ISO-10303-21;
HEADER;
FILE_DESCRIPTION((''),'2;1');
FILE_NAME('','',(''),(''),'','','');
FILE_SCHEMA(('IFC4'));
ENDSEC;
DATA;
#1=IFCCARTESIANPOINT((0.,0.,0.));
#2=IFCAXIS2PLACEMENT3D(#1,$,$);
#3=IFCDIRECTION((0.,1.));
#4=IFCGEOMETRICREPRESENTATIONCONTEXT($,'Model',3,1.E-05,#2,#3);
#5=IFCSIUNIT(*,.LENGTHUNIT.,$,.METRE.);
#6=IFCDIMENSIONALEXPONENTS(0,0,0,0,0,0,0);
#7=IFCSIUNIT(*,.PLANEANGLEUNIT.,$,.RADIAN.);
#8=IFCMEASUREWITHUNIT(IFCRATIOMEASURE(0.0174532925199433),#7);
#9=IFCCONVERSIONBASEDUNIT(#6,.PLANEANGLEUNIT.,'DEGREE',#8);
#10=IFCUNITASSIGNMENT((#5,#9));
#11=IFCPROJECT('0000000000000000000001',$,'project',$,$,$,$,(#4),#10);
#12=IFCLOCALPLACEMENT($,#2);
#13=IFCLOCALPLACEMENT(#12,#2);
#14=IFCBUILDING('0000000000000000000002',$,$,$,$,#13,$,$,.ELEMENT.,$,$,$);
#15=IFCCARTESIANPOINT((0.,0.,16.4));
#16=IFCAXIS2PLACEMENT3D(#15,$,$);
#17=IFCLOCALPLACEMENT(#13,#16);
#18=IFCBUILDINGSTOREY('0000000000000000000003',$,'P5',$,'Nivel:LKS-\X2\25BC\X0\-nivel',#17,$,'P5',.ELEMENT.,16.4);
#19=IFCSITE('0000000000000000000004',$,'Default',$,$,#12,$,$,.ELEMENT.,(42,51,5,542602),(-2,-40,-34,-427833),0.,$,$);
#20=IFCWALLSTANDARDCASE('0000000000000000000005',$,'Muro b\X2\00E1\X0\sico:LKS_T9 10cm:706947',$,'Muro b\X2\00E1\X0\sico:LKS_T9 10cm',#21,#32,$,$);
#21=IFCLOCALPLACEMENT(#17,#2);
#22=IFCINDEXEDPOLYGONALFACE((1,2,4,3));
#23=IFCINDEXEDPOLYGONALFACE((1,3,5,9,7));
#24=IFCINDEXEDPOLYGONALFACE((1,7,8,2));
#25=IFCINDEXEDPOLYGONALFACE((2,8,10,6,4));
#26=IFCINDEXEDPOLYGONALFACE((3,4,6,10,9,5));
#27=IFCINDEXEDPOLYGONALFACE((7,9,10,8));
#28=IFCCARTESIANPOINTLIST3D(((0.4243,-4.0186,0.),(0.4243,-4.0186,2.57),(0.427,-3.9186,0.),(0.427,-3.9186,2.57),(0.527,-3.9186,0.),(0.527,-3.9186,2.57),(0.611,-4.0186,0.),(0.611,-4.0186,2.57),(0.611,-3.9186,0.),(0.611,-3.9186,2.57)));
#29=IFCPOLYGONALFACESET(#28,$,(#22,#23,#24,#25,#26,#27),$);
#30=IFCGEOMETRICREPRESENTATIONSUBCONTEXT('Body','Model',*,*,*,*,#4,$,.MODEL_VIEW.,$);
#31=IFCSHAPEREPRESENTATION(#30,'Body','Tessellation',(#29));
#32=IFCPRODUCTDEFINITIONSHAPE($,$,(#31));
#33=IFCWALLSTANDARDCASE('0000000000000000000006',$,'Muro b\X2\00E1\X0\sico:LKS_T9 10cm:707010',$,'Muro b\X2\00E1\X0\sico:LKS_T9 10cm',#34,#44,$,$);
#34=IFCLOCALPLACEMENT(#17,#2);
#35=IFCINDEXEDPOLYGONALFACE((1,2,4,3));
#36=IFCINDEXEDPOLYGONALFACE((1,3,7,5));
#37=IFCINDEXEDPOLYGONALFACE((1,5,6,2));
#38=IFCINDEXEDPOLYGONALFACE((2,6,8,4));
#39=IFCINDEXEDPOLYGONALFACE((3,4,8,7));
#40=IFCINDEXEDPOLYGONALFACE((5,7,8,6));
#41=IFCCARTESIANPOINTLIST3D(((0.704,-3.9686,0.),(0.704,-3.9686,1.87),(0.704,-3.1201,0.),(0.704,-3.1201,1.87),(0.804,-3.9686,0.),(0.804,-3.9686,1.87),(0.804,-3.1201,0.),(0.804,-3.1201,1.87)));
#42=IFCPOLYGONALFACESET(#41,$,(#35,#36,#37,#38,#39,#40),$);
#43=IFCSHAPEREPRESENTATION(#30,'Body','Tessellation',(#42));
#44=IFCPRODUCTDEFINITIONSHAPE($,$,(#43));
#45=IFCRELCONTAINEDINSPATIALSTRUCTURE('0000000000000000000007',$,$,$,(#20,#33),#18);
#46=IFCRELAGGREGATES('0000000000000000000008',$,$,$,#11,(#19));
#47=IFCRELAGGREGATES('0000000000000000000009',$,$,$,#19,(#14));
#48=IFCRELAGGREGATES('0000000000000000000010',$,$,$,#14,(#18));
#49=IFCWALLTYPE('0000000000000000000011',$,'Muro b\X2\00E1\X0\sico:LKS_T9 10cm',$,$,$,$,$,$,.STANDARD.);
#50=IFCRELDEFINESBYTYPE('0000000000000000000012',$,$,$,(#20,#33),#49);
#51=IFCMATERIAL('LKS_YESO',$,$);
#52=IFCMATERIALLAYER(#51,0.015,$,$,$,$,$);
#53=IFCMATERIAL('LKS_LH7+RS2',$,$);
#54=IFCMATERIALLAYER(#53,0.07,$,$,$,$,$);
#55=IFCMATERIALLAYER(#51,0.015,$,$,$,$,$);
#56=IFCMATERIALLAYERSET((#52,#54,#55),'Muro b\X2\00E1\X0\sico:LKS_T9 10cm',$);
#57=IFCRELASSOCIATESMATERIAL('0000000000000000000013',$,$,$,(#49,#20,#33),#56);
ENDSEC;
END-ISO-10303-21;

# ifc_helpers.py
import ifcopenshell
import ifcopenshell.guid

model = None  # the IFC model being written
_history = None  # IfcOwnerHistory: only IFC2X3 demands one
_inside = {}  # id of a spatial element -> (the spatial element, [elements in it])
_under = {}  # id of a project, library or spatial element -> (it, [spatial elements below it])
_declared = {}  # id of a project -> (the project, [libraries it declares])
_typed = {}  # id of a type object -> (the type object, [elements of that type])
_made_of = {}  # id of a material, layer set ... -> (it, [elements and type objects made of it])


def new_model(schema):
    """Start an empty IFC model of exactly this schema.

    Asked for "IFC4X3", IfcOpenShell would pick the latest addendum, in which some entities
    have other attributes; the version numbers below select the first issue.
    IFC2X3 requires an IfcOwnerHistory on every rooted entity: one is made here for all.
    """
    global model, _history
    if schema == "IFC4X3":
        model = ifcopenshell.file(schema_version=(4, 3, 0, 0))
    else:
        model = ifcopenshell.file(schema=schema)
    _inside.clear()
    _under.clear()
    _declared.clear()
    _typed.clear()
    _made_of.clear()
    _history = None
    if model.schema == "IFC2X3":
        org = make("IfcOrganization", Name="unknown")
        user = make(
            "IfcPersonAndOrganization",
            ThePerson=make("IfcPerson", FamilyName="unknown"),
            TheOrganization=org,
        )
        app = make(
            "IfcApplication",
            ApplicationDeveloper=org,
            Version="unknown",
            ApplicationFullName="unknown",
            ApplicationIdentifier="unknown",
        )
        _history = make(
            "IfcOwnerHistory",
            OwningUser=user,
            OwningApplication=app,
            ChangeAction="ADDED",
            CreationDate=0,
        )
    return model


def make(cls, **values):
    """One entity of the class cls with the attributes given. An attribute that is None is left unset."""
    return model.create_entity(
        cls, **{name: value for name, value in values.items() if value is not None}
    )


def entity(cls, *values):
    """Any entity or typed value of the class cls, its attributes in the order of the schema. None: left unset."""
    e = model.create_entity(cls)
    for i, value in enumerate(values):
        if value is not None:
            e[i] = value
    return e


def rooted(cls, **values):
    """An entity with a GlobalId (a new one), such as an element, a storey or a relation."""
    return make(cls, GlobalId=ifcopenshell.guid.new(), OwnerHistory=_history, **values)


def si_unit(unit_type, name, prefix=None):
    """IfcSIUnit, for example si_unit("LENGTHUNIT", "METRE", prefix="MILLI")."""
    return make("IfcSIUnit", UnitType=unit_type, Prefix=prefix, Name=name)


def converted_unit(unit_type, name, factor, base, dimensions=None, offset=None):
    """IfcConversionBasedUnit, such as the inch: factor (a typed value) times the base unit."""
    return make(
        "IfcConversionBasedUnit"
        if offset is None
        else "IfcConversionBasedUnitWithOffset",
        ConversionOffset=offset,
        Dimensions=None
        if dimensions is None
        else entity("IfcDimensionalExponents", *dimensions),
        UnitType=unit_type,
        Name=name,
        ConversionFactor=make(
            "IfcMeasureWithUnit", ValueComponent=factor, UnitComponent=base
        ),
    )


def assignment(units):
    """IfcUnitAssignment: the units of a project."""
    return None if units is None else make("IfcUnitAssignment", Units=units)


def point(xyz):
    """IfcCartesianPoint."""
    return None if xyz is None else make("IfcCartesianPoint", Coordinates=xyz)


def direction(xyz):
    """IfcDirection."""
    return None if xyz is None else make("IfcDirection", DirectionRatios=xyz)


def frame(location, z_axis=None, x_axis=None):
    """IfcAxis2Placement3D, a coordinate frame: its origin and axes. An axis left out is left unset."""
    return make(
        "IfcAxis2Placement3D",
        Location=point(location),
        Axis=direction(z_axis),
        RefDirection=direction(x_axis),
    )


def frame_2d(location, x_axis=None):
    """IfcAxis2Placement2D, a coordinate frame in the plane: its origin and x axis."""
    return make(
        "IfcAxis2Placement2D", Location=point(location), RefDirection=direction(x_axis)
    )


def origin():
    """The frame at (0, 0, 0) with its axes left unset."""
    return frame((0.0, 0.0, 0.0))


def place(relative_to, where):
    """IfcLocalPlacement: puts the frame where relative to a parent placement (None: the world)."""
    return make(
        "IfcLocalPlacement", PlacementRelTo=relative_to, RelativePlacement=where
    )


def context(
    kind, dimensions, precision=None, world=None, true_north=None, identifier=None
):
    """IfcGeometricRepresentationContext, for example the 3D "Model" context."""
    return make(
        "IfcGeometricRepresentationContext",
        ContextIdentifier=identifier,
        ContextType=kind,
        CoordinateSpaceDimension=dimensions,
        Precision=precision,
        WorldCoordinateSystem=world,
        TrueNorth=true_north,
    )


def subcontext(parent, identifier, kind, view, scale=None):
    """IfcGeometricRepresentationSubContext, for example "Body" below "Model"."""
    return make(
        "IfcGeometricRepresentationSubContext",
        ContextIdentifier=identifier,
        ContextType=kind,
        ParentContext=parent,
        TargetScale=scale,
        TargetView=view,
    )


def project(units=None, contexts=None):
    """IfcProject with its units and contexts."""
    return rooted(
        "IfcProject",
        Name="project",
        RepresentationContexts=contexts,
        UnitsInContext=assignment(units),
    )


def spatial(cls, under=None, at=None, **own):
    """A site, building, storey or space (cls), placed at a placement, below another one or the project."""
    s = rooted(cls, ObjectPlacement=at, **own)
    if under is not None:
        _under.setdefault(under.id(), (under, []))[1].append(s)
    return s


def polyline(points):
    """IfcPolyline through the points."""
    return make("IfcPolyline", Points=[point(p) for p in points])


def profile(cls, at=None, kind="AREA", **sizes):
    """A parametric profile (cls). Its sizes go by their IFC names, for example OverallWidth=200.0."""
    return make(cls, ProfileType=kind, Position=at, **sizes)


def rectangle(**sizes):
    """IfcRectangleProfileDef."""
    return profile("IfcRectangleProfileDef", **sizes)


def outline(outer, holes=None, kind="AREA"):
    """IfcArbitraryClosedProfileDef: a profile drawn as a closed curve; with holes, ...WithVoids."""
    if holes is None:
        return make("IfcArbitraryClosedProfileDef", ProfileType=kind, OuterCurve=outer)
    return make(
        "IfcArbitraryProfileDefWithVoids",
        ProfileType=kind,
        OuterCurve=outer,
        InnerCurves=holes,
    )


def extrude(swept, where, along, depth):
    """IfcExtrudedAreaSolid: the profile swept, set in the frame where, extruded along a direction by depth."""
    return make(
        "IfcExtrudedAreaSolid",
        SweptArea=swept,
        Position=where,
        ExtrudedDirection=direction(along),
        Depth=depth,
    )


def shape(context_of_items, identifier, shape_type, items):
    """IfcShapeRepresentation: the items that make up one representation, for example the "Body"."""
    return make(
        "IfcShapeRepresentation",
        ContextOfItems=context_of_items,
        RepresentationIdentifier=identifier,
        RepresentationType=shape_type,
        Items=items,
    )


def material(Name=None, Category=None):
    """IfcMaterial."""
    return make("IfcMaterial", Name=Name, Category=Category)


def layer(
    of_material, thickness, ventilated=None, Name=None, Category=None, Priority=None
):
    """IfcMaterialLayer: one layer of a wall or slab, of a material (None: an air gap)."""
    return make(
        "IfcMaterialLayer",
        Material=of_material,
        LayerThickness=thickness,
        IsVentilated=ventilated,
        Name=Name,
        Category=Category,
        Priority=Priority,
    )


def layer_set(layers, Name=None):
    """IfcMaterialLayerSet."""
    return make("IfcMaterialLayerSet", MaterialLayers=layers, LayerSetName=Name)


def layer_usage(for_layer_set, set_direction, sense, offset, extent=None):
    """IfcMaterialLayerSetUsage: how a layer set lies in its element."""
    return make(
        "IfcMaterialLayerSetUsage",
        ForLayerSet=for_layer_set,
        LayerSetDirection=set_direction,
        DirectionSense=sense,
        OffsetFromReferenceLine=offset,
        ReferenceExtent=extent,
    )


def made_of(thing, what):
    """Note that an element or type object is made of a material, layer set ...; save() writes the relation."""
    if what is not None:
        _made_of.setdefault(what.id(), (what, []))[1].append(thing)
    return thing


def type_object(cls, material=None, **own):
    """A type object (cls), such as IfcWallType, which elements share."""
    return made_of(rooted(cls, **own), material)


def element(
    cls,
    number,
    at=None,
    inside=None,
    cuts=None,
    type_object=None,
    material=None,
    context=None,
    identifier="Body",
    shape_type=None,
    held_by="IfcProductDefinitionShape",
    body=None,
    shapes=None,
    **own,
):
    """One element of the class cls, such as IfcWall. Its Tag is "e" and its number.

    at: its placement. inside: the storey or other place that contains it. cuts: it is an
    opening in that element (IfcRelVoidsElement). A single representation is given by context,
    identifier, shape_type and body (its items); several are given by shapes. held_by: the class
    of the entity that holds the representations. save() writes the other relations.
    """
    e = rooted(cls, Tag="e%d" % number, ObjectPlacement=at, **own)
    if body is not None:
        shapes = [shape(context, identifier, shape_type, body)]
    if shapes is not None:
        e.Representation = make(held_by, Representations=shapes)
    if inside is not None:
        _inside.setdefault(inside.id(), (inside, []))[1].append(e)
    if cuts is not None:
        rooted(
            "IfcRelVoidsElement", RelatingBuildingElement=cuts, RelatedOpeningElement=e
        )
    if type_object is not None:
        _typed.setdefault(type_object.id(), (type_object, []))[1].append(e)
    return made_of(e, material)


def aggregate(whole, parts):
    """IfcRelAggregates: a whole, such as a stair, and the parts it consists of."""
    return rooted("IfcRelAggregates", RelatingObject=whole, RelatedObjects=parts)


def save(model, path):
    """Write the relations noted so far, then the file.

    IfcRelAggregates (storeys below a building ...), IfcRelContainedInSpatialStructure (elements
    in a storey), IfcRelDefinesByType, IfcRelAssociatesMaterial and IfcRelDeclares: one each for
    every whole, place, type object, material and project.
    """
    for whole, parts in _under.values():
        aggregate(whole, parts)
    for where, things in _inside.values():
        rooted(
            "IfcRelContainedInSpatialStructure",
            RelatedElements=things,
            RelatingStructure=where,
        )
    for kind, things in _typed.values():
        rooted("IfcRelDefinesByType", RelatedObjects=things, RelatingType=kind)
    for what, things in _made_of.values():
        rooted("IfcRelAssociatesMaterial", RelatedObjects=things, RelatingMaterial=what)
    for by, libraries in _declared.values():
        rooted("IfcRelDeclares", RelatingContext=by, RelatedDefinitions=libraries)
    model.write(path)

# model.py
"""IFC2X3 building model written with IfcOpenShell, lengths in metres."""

from ifc_helpers import new_model, entity, si_unit, converted_unit, direction, frame, frame_2d, origin, place, context, subcontext, project, spatial, polyline, rectangle, outline, extrude, material, layer, layer_set, layer_usage, type_object, element, save


model = new_model("IFC2X3")

# Units and contexts
model_context = context("Model", 3, precision=1e-05, world=origin(), true_north=direction((0.0, 1.0)))
body_context = subcontext(model_context, "Body", "Model", "MODEL_VIEW")
ifc_project = project(units=[si_unit("LENGTHUNIT", "METRE"), converted_unit("PLANEANGLEUNIT", "DEGREE", entity("IfcRatioMeasure", 0.0174532925199433), si_unit("PLANEANGLEUNIT", "RADIAN"), dimensions=[0, 0, 0, 0, 0, 0, 0])], contexts=[model_context])

# Site, building, storey
site_placement = place(None, origin())
site = spatial("IfcSite", under=ifc_project, at=site_placement, Name="Default", CompositionType="ELEMENT", RefLatitude=(42, 51, 5, 542602), RefLongitude=(-2, -40, -34, -427833), RefElevation=0.0)
building_placement = place(site_placement, origin())
building = spatial("IfcBuilding", under=site, at=building_placement, CompositionType="ELEMENT")
storey_placement = place(building_placement, frame((0.0, 0.0, 16.4)))
storey = spatial("IfcBuildingStorey", under=building, at=storey_placement, Name="P5", ObjectType="Nivel:LKS-▼-nivel", LongName="P5", CompositionType="ELEMENT", Elevation=16.4)

# Shared definitions
ifc_material_1 = material(Name="LKS_YESO")

# Walls
ifc_layer_1 = layer(ifc_material_1, 0.015)
ifc_material_2 = material(Name="LKS_LH7+RS2")
ifc_layer_2 = layer(ifc_material_2, 0.07)
ifc_layer_3 = layer(ifc_material_1, 0.015)
ifc_layer_set_1 = layer_set([ifc_layer_1, ifc_layer_2, ifc_layer_3], Name="Muro básico:LKS_T9 10cm")
wall_type_1 = type_object("IfcWallType", Name="Muro básico:LKS_T9 10cm", PredefinedType="STANDARD", material=ifc_layer_set_1)
ifc_layer_usage_1 = layer_usage(ifc_layer_set_1, "AXIS2", "POSITIVE", -0.05)
wall_1_placement = place(storey_placement, frame((0.4243, -3.9686, 0.0)))
element("IfcWallStandardCase", 1, at=wall_1_placement, inside=storey, type_object=wall_type_1, material=ifc_layer_usage_1, Name="Muro básico:LKS_T9 10cm:706947", ObjectType="Muro básico:LKS_T9 10cm", context=body_context, shape_type="SweptSolid", body=[
    extrude(outline(polyline([(0.1867, -0.05), (0.1867, 0.05), (0.1027, 0.05), (0.0027, 0.05), (0.0, -0.05), (0.1867, -0.05)])), origin(), (0.0, 0.0, 1.0), 2.57),
])
ifc_layer_usage_2 = layer_usage(ifc_layer_set_1, "AXIS2", "POSITIVE", -0.05)
wall_2_placement = place(storey_placement, frame((0.754, -3.9686, 0.0), z_axis=(0.0, 0.0, 1.0), x_axis=(0.0, 1.0, 0.0)))
element("IfcWallStandardCase", 2, at=wall_2_placement, inside=storey, type_object=wall_type_1, material=ifc_layer_usage_2, Name="Muro básico:LKS_T9 10cm:707010", ObjectType="Muro básico:LKS_T9 10cm", context=body_context, shape_type="SweptSolid", body=[
    extrude(rectangle(XDim=0.8485, YDim=0.1, at=frame_2d((0.4242, 0.0), x_axis=(-1.0, 0.0))), origin(), (0.0, 0.0, 1.0), 1.87),
])

save(model, "model.ifc")
